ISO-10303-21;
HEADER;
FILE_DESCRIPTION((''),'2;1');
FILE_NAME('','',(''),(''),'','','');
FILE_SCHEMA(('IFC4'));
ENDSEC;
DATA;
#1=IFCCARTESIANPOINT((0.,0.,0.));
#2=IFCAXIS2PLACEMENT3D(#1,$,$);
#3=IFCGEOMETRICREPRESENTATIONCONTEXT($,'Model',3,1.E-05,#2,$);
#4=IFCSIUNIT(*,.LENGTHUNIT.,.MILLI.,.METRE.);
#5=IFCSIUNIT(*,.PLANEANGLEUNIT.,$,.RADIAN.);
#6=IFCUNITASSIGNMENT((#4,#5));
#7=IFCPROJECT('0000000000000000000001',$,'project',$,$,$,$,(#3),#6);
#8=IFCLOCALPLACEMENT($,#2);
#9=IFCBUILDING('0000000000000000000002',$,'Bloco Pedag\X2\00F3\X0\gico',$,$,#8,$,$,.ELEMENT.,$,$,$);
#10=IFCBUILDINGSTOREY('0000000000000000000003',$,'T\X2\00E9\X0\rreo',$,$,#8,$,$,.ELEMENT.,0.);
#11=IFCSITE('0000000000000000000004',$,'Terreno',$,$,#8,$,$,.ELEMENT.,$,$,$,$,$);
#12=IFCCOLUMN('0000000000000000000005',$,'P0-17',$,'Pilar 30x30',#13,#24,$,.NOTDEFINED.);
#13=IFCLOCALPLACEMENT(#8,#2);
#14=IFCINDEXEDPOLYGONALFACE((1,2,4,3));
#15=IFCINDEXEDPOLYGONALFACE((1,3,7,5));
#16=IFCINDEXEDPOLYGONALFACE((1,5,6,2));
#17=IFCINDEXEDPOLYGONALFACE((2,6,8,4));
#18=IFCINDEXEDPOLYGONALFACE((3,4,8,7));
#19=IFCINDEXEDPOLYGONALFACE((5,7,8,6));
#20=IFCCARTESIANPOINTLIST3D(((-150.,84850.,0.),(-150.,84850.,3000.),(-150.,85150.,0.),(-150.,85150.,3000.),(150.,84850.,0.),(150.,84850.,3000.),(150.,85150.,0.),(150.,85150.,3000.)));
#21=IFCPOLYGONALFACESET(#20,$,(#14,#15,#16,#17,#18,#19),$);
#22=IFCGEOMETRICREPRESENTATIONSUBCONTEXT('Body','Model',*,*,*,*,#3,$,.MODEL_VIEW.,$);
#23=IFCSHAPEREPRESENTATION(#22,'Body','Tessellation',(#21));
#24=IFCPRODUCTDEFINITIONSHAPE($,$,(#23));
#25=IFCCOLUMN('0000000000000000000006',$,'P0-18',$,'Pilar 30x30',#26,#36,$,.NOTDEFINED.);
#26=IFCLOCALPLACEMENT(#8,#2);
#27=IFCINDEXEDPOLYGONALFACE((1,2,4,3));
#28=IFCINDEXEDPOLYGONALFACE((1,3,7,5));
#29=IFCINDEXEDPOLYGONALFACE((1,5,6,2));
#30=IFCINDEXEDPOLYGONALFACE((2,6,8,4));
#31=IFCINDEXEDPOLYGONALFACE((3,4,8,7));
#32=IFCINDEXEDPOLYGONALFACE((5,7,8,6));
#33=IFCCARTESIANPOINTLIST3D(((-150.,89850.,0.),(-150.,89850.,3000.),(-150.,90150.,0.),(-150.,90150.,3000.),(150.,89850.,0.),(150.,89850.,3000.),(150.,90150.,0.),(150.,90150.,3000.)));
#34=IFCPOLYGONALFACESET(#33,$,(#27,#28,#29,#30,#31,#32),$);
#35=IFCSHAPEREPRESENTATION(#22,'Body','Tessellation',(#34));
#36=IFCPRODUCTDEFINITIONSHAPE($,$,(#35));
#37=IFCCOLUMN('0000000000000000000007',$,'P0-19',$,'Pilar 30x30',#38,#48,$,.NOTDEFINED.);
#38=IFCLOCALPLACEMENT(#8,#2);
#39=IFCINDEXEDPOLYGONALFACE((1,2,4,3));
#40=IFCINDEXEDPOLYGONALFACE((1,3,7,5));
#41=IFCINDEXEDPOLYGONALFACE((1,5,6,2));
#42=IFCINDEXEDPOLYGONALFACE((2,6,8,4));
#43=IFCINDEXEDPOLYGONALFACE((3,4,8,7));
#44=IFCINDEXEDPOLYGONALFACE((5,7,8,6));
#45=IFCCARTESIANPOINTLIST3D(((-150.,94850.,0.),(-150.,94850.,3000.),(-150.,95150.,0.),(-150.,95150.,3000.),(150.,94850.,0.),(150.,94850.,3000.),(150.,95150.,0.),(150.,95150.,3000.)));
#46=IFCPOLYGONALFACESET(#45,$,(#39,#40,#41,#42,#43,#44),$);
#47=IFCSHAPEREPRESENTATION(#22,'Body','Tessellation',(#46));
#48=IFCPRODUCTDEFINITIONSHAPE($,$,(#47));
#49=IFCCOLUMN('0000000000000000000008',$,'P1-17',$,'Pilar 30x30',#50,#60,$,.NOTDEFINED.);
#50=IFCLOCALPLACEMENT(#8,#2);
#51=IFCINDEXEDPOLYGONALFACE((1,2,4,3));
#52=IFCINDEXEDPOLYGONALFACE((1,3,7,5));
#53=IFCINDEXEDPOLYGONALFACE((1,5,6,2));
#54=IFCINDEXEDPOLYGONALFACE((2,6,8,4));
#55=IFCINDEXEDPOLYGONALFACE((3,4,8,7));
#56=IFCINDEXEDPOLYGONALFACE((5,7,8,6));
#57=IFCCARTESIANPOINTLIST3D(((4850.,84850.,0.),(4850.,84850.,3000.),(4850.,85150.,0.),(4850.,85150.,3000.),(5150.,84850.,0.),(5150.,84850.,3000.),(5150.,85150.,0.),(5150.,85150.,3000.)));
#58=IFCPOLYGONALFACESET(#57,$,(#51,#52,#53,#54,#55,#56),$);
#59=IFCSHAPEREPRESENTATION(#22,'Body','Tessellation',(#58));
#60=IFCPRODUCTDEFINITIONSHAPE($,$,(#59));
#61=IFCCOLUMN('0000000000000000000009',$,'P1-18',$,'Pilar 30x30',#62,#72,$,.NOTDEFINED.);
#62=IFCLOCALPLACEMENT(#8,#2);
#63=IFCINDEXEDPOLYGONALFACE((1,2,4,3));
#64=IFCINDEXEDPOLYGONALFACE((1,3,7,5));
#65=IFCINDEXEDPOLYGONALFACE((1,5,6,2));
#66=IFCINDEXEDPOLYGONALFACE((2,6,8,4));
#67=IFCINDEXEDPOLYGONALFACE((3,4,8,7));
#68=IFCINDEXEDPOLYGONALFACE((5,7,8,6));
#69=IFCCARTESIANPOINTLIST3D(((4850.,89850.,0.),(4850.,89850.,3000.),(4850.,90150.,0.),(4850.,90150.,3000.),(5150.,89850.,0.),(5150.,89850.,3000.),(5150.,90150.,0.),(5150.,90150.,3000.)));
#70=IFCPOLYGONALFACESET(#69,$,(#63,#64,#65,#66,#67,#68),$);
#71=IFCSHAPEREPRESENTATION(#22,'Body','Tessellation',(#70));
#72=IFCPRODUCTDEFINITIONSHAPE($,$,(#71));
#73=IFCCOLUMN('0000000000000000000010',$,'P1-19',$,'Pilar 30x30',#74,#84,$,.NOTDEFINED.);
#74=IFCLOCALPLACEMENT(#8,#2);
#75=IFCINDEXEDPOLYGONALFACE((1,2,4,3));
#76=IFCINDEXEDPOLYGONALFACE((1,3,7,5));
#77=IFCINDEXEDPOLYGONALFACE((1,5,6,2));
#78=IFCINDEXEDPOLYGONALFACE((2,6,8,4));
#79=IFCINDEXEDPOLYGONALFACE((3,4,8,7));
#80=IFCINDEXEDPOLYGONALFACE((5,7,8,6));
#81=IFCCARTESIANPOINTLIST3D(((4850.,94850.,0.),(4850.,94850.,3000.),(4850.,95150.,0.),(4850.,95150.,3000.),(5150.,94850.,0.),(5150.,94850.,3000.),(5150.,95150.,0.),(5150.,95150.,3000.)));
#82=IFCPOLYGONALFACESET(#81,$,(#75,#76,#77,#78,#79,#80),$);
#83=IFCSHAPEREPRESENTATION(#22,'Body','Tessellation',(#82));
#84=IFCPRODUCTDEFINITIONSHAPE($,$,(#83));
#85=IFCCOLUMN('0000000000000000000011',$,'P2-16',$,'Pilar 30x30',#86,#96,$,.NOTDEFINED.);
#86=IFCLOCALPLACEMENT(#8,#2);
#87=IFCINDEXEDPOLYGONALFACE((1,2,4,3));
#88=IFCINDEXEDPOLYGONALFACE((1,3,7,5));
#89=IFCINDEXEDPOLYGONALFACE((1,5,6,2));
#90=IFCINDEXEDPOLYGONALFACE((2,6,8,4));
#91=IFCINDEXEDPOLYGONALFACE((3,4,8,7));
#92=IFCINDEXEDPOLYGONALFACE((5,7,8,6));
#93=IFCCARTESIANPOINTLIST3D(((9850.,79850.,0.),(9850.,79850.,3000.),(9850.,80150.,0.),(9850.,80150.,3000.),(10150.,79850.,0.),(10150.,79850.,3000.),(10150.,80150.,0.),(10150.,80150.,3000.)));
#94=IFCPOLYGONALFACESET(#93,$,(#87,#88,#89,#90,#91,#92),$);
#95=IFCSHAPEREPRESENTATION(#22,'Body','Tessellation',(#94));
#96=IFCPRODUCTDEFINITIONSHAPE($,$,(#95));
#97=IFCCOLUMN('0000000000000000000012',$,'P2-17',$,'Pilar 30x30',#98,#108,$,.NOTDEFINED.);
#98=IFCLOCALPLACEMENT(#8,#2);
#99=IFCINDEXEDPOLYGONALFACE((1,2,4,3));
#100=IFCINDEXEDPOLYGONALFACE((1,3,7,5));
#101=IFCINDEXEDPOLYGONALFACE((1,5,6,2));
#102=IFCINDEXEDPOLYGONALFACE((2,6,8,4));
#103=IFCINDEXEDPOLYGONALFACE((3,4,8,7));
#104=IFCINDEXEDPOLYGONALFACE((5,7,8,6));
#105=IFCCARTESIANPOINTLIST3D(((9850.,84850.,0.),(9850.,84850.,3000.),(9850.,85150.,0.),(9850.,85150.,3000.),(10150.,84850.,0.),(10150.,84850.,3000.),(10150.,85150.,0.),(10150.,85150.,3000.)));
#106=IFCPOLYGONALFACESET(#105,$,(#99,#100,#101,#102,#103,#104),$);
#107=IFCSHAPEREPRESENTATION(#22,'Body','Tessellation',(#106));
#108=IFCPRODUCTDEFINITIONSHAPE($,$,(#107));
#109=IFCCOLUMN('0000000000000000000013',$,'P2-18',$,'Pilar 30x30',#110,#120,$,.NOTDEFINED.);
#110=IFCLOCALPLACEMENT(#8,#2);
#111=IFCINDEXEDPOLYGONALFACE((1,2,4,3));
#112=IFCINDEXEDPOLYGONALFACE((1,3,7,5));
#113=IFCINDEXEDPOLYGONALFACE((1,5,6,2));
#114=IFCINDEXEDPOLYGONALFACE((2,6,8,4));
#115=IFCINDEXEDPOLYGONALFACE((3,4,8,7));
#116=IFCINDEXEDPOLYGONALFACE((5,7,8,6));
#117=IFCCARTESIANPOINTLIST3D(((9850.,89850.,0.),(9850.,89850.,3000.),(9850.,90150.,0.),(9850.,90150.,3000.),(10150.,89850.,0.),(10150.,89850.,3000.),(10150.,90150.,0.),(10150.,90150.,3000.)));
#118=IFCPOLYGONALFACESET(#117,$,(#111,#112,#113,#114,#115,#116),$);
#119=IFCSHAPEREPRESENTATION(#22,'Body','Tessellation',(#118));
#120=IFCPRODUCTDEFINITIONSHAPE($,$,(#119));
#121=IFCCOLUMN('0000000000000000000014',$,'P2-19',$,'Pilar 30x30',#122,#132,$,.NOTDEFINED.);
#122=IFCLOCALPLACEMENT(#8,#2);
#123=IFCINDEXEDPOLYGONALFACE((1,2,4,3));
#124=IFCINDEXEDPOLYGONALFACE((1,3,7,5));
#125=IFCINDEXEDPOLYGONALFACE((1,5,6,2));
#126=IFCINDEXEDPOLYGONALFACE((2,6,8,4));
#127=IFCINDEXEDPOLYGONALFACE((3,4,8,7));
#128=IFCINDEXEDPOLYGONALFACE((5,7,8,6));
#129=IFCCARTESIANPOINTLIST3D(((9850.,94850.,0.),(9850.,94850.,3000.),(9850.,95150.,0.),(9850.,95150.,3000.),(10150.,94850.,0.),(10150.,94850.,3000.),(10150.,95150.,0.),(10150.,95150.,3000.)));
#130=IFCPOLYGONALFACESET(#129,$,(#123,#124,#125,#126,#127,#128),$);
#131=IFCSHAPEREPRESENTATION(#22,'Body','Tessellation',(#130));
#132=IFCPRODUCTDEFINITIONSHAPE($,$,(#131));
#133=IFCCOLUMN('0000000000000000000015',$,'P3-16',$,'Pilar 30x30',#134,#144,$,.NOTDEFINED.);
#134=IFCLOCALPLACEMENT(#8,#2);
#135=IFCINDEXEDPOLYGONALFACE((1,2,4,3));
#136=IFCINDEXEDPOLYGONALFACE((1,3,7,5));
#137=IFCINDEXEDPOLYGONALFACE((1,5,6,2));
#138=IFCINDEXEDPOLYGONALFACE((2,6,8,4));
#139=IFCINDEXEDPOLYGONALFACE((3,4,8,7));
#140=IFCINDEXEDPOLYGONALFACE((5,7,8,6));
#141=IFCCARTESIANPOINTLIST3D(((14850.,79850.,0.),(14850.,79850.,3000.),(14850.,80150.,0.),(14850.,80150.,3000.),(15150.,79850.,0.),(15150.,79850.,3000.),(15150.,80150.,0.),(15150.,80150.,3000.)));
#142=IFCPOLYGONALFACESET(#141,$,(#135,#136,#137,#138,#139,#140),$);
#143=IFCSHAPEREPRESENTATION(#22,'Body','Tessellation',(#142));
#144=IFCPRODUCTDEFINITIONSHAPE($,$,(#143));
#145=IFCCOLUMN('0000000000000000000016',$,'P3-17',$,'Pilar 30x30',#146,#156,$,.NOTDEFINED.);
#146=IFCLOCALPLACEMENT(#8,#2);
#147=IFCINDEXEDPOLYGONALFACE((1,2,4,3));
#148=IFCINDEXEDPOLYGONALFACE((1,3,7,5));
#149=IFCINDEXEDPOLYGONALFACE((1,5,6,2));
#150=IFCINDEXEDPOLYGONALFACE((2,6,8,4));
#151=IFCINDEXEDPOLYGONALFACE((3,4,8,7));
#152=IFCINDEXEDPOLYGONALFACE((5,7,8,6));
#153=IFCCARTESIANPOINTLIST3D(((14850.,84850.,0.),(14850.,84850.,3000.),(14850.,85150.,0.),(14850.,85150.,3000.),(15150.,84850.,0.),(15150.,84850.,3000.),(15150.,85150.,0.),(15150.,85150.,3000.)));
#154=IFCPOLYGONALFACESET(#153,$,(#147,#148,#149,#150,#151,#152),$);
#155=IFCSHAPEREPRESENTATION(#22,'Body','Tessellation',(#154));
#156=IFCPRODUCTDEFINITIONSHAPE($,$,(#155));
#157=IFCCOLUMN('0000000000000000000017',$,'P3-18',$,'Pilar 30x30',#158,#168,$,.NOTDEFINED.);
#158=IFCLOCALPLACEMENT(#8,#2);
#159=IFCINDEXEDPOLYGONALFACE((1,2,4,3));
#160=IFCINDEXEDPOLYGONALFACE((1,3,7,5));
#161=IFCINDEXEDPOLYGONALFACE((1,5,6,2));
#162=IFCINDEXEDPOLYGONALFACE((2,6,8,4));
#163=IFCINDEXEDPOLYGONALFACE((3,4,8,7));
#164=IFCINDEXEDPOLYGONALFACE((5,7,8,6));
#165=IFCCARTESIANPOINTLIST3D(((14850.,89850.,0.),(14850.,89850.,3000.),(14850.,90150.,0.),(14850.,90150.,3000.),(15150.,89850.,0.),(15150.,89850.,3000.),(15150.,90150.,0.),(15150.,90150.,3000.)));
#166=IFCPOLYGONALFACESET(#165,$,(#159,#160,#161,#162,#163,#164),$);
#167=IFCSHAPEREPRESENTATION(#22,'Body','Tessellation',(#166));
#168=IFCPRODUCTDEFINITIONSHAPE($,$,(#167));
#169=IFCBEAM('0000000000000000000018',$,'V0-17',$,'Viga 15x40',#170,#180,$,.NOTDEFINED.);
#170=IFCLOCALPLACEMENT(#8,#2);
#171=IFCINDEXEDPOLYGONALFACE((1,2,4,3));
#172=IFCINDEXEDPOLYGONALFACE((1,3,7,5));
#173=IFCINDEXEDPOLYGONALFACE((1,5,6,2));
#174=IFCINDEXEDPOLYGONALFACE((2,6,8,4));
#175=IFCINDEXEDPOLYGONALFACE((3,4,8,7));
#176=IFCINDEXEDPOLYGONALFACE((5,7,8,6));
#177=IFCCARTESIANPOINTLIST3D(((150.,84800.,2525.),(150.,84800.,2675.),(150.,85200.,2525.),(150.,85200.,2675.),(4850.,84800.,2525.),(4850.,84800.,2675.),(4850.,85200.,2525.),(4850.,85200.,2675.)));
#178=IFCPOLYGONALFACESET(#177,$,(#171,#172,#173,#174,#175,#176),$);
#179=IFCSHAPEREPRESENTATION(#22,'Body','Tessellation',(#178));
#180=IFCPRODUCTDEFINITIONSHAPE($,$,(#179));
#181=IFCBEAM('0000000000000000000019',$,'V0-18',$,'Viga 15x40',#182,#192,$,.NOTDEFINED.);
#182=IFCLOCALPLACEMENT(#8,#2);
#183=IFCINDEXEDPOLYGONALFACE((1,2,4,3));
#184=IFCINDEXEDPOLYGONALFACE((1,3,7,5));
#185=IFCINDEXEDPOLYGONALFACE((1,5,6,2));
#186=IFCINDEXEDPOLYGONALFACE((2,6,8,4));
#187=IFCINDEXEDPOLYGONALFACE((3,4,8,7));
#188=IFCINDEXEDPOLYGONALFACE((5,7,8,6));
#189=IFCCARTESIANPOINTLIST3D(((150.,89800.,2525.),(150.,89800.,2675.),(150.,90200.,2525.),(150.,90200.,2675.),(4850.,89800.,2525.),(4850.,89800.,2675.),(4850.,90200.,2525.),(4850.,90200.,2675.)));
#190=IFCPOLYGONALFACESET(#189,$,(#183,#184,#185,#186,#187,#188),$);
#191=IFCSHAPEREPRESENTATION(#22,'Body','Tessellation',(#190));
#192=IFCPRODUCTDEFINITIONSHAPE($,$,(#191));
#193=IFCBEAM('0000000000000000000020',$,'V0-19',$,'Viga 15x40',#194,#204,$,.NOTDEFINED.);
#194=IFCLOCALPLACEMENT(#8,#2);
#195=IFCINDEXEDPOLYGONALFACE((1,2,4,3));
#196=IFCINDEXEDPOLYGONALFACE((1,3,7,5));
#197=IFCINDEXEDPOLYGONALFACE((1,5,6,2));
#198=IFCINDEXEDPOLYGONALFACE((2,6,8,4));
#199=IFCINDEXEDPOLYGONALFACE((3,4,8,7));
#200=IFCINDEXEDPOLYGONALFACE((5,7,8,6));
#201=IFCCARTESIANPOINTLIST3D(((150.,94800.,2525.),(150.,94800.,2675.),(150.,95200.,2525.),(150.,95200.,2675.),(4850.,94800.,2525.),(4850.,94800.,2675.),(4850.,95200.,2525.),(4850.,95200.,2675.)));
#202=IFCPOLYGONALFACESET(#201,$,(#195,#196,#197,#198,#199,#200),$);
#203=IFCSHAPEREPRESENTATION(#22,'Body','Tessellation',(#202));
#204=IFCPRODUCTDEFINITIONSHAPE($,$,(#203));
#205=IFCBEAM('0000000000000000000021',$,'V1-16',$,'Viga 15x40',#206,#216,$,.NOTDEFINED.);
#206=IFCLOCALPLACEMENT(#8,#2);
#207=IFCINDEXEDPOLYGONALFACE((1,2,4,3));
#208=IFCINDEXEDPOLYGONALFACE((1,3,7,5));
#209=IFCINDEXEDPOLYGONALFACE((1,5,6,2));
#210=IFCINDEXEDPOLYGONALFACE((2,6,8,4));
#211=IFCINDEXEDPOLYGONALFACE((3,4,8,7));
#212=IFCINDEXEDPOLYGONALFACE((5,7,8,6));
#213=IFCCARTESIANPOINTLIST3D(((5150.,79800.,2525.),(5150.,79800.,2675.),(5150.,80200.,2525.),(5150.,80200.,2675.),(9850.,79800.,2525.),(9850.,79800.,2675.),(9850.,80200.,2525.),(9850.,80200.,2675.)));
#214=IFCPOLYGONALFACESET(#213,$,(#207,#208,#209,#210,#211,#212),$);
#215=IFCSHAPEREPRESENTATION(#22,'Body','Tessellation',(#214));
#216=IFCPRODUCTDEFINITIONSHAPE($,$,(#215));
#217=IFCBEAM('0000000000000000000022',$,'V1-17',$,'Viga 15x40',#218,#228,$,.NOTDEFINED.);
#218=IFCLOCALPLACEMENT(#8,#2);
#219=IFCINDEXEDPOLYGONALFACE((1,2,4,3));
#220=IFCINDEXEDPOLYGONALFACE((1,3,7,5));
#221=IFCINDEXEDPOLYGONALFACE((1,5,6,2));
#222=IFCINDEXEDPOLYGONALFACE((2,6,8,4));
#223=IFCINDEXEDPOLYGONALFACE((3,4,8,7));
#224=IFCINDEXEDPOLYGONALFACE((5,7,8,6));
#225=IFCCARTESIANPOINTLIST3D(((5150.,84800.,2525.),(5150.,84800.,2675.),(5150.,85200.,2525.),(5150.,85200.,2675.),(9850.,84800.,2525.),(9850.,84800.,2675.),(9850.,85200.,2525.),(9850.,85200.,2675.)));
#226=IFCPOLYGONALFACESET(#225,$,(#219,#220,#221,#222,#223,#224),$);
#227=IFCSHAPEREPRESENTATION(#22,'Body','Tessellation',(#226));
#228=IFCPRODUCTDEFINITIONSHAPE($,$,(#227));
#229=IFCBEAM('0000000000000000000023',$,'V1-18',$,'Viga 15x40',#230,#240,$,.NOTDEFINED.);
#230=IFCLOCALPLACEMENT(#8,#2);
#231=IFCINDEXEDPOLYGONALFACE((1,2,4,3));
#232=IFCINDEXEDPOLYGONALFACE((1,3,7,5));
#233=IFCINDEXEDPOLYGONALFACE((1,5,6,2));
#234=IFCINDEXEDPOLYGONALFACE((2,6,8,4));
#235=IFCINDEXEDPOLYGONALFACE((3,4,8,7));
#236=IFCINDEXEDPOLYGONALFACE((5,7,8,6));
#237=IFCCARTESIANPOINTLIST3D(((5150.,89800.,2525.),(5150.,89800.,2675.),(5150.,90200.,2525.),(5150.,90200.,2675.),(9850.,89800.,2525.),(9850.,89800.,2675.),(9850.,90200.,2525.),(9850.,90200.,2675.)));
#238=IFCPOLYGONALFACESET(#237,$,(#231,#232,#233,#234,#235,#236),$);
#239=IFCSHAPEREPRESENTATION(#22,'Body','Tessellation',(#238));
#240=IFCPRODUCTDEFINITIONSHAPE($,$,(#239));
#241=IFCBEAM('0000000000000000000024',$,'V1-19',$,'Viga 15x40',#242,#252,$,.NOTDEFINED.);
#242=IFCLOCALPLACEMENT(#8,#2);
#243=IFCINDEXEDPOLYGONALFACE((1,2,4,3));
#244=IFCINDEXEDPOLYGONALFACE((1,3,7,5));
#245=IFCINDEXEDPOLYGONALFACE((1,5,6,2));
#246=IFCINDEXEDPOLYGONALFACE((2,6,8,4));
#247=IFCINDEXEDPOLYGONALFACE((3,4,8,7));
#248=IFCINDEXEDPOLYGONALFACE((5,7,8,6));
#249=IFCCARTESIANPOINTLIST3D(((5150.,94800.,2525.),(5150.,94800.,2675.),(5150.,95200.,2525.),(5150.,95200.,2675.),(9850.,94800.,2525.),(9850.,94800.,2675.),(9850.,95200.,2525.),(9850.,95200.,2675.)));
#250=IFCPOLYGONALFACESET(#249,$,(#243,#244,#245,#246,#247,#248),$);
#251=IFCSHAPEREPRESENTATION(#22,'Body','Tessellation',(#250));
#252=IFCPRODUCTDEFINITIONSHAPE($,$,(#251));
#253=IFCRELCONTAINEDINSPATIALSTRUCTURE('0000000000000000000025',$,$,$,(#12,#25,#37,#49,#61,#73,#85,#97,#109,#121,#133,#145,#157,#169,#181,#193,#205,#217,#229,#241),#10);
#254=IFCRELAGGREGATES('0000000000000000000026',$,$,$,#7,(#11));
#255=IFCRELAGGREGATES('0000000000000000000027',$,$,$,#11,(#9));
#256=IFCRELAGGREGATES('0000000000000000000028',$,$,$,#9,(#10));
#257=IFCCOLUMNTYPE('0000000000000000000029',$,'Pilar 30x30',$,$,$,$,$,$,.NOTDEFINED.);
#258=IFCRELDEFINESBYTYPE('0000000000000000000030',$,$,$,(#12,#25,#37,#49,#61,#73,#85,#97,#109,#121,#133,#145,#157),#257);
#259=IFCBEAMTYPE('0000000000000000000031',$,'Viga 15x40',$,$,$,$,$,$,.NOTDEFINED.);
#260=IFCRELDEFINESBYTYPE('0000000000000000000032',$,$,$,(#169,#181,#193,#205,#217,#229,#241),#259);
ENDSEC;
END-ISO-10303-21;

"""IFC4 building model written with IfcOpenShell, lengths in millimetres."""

from ifc_helpers import new_model, si_unit, frame, origin, origin_2d, place, context, subcontext, project, spatial, rectangle, extrude, type_object, element, save


model = new_model("IFC4")

# Units and contexts
model_context = context("Model", 3, precision=1e-05, world=origin())
body_context = subcontext(model_context, "Body", "Model", "MODEL_VIEW")
ifc_project = project(units=[si_unit("LENGTHUNIT", "METRE", prefix="MILLI"), si_unit("PLANEANGLEUNIT", "RADIAN")], contexts=[model_context])

# Site, building, storey
placement = place(None, origin())
site = spatial("IfcSite", under=ifc_project, at=placement, Name="Terreno", CompositionType="ELEMENT")
building = spatial("IfcBuilding", under=site, at=placement, Name="Bloco Pedagógico", CompositionType="ELEMENT")
storey = spatial("IfcBuildingStorey", under=building, at=placement, Name="Térreo", CompositionType="ELEMENT", Elevation=0.0)

# Columns
column_type = type_object("IfcColumnType", Name="Pilar 30x30", PredefinedType="NOTDEFINED")
for number, where, z_axis, x_axis, name in (
    (1, (0.0, 85000.0, 0.0), (0.0, 0.0, 1.0), (1.0, 0.0, 0.0), "P0-17"),
    (2, (0.0, 90000.0, 0.0), (0.0, 0.0, 1.0), (1.0, 0.0, 0.0), "P0-18"),
    (3, (0.0, 95000.0, 0.0), (0.0, 0.0, 1.0), (1.0, 0.0, 0.0), "P0-19"),
    (4, (5000.0, 85000.0, 0.0), (0.0, 0.0, 1.0), (1.0, 0.0, 0.0), "P1-17"),
    (5, (5000.0, 90000.0, 0.0), (0.0, 0.0, 1.0), (1.0, 0.0, 0.0), "P1-18"),
    (6, (5000.0, 95000.0, 0.0), (0.0, 0.0, 1.0), (1.0, 0.0, 0.0), "P1-19"),
    (7, (10000.0, 80000.0, 0.0), (0.0, 0.0, 1.0), (1.0, 0.0, 0.0), "P2-16"),
    (8, (10000.0, 85000.0, 0.0), (0.0, 0.0, 1.0), (1.0, 0.0, 0.0), "P2-17"),
    (9, (10000.0, 90000.0, 0.0), (0.0, 0.0, 1.0), (1.0, 0.0, 0.0), "P2-18"),
    (10, (10000.0, 95000.0, 0.0), (0.0, 0.0, 1.0), (1.0, 0.0, 0.0), "P2-19"),
    (11, (15000.0, 80000.0, 0.0), (0.0, 0.0, 1.0), (1.0, 0.0, 0.0), "P3-16"),
    (12, (15000.0, 85000.0, 0.0), (0.0, 0.0, 1.0), (1.0, 0.0, 0.0), "P3-17"),
    (13, (15000.0, 90000.0, 0.0), (0.0, 0.0, 1.0), (1.0, 0.0, 0.0), "P3-18"),
):
    element("IfcColumn", number, at=place(None, frame(where, z_axis=z_axis, x_axis=x_axis)), inside=storey, type_object=column_type, Name=name, ObjectType="Pilar 30x30", PredefinedType="NOTDEFINED", context=body_context, shape_type="SweptSolid", body=[
        extrude(rectangle(XDim=300.0, YDim=300.0, at=origin_2d()), None, (0.0, 0.0, 1.0), 3000.0),
    ])

# Beams
beam_type = type_object("IfcBeamType", Name="Viga 15x40", PredefinedType="NOTDEFINED")
for number, where, z_axis, x_axis, name in (
    (14, (150.0, 85000.0, 2600.0), (1.0, 0.0, 0.0), (0.0, 1.0, 0.0), "V0-17"),
    (15, (150.0, 90000.0, 2600.0), (1.0, 0.0, 0.0), (0.0, 1.0, 0.0), "V0-18"),
    (16, (150.0, 95000.0, 2600.0), (1.0, 0.0, 0.0), (0.0, 1.0, 0.0), "V0-19"),
    (17, (5150.0, 80000.0, 2600.0), (1.0, 0.0, 0.0), (0.0, 1.0, 0.0), "V1-16"),
    (18, (5150.0, 85000.0, 2600.0), (1.0, 0.0, 0.0), (0.0, 1.0, 0.0), "V1-17"),
    (19, (5150.0, 90000.0, 2600.0), (1.0, 0.0, 0.0), (0.0, 1.0, 0.0), "V1-18"),
    (20, (5150.0, 95000.0, 2600.0), (1.0, 0.0, 0.0), (0.0, 1.0, 0.0), "V1-19"),
):
    element("IfcBeam", number, at=place(None, frame(where, z_axis=z_axis, x_axis=x_axis)), inside=storey, type_object=beam_type, Name=name, ObjectType="Viga 15x40", PredefinedType="NOTDEFINED", context=body_context, shape_type="SweptSolid", body=[
        extrude(rectangle(XDim=400.0, YDim=150.0, at=origin_2d()), None, (0.0, 0.0, 1.0), 4700.0),
    ])

save(model, "model.ifc")
